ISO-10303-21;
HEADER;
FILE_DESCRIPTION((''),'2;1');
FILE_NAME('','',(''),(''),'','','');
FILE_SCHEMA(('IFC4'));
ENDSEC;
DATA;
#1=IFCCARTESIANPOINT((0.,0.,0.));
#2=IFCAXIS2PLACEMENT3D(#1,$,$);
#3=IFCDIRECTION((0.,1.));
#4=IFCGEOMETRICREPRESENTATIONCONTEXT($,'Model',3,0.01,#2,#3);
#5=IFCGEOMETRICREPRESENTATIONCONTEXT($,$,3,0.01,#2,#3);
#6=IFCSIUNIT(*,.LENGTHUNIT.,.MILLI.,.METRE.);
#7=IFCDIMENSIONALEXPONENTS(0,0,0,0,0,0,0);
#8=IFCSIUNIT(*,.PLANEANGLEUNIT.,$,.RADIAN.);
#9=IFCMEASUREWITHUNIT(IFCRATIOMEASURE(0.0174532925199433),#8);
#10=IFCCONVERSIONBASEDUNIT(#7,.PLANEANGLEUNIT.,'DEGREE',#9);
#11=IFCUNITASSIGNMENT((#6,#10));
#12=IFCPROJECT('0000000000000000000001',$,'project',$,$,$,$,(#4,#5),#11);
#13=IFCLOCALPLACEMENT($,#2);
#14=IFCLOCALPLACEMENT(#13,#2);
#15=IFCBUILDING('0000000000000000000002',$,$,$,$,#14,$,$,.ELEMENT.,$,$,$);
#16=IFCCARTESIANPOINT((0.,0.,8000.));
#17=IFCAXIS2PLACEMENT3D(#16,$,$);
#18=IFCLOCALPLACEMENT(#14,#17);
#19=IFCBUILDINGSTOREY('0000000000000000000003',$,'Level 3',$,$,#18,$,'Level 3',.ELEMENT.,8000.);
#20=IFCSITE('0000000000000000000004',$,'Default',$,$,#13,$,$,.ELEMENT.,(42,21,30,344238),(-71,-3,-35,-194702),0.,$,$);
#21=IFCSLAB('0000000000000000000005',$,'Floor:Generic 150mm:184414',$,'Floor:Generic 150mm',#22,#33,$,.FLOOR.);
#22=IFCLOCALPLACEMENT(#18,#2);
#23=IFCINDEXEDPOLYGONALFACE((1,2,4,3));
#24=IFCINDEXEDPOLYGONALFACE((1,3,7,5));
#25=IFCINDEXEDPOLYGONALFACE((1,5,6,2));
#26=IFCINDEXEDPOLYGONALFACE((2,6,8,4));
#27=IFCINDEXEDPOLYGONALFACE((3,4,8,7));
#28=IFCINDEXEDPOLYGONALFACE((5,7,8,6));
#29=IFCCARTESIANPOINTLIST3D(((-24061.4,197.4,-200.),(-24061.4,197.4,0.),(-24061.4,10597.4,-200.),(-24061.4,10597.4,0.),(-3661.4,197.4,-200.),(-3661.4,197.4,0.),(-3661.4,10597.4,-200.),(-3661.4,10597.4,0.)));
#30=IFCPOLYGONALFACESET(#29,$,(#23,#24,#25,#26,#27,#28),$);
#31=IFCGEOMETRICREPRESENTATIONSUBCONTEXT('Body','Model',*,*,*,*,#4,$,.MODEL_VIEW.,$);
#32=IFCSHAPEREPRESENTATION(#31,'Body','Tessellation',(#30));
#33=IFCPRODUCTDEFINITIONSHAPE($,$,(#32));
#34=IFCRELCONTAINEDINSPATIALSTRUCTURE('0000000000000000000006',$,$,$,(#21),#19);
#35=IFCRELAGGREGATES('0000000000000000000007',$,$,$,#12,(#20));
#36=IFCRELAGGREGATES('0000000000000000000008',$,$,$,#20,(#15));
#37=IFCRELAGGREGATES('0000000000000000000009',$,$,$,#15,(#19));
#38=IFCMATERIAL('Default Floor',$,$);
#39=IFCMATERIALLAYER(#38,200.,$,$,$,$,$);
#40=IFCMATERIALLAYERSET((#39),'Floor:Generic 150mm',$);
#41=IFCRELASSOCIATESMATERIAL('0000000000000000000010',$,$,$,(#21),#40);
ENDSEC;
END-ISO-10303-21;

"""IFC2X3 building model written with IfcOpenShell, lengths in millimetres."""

from ifc_helpers import new_model, entity, si_unit, converted_unit, direction, frame, origin, origin_2d_with_axis, place, context, subcontext, project, spatial, rectangle, extrude, material, layer, layer_set, layer_usage, element, save


model = new_model("IFC2X3")

# Units and contexts
model_context = context("Model", 3, precision=0.01, world=origin(), true_north=direction((0.0, 1.0)))
context_of_model = context(None, 3, precision=0.01, world=origin(), true_north=direction((0.0, 1.0)))
body_context = subcontext(model_context, "Body", "Model", "MODEL_VIEW")
ifc_project = project(units=[si_unit("LENGTHUNIT", "METRE", prefix="MILLI"), converted_unit("PLANEANGLEUNIT", "DEGREE", entity("IfcRatioMeasure", 0.0174532925199433), si_unit("PLANEANGLEUNIT", "RADIAN"), dimensions=[0, 0, 0, 0, 0, 0, 0])], contexts=[model_context, context_of_model])

# Site, building, storey
site_placement = place(None, origin())
site = spatial("IfcSite", under=ifc_project, at=site_placement, Name="Default", CompositionType="ELEMENT", RefLatitude=(42, 21, 30, 344238), RefLongitude=(-71, -3, -35, -194702), RefElevation=0.0)
building_placement = place(site_placement, origin())
building = spatial("IfcBuilding", under=site, at=building_placement, CompositionType="ELEMENT")
storey_placement = place(building_placement, frame((0.0, 0.0, 8000.0)))
storey = spatial("IfcBuildingStorey", under=building, at=storey_placement, Name="Level 3", LongName="Level 3", CompositionType="ELEMENT", Elevation=8000.0)

# Slab
ifc_material = material(Name="Default Floor")
ifc_layer = layer(ifc_material, 200.0)
ifc_layer_set = layer_set([ifc_layer], Name="Floor:Generic 150mm")
ifc_layer_usage = layer_usage(ifc_layer_set, "AXIS3", "POSITIVE", 0.0)
slab_placement = place(storey_placement, origin())
element("IfcSlab", 1, at=slab_placement, inside=storey, material=ifc_layer_usage, Name="Floor:Generic 150mm:184414", ObjectType="Floor:Generic 150mm", PredefinedType="FLOOR", context=body_context, shape_type="SweptSolid", body=[
    extrude(rectangle(XDim=10400.0, YDim=20400.0, at=origin_2d_with_axis()), frame((-13861.4, 5397.4, 0.0), z_axis=(0.0, 0.0, -1.0), x_axis=(0.0, 1.0, 0.0)), (0.0, 0.0, 1.0), 200.0),
])

save(model, "model.ifc")
